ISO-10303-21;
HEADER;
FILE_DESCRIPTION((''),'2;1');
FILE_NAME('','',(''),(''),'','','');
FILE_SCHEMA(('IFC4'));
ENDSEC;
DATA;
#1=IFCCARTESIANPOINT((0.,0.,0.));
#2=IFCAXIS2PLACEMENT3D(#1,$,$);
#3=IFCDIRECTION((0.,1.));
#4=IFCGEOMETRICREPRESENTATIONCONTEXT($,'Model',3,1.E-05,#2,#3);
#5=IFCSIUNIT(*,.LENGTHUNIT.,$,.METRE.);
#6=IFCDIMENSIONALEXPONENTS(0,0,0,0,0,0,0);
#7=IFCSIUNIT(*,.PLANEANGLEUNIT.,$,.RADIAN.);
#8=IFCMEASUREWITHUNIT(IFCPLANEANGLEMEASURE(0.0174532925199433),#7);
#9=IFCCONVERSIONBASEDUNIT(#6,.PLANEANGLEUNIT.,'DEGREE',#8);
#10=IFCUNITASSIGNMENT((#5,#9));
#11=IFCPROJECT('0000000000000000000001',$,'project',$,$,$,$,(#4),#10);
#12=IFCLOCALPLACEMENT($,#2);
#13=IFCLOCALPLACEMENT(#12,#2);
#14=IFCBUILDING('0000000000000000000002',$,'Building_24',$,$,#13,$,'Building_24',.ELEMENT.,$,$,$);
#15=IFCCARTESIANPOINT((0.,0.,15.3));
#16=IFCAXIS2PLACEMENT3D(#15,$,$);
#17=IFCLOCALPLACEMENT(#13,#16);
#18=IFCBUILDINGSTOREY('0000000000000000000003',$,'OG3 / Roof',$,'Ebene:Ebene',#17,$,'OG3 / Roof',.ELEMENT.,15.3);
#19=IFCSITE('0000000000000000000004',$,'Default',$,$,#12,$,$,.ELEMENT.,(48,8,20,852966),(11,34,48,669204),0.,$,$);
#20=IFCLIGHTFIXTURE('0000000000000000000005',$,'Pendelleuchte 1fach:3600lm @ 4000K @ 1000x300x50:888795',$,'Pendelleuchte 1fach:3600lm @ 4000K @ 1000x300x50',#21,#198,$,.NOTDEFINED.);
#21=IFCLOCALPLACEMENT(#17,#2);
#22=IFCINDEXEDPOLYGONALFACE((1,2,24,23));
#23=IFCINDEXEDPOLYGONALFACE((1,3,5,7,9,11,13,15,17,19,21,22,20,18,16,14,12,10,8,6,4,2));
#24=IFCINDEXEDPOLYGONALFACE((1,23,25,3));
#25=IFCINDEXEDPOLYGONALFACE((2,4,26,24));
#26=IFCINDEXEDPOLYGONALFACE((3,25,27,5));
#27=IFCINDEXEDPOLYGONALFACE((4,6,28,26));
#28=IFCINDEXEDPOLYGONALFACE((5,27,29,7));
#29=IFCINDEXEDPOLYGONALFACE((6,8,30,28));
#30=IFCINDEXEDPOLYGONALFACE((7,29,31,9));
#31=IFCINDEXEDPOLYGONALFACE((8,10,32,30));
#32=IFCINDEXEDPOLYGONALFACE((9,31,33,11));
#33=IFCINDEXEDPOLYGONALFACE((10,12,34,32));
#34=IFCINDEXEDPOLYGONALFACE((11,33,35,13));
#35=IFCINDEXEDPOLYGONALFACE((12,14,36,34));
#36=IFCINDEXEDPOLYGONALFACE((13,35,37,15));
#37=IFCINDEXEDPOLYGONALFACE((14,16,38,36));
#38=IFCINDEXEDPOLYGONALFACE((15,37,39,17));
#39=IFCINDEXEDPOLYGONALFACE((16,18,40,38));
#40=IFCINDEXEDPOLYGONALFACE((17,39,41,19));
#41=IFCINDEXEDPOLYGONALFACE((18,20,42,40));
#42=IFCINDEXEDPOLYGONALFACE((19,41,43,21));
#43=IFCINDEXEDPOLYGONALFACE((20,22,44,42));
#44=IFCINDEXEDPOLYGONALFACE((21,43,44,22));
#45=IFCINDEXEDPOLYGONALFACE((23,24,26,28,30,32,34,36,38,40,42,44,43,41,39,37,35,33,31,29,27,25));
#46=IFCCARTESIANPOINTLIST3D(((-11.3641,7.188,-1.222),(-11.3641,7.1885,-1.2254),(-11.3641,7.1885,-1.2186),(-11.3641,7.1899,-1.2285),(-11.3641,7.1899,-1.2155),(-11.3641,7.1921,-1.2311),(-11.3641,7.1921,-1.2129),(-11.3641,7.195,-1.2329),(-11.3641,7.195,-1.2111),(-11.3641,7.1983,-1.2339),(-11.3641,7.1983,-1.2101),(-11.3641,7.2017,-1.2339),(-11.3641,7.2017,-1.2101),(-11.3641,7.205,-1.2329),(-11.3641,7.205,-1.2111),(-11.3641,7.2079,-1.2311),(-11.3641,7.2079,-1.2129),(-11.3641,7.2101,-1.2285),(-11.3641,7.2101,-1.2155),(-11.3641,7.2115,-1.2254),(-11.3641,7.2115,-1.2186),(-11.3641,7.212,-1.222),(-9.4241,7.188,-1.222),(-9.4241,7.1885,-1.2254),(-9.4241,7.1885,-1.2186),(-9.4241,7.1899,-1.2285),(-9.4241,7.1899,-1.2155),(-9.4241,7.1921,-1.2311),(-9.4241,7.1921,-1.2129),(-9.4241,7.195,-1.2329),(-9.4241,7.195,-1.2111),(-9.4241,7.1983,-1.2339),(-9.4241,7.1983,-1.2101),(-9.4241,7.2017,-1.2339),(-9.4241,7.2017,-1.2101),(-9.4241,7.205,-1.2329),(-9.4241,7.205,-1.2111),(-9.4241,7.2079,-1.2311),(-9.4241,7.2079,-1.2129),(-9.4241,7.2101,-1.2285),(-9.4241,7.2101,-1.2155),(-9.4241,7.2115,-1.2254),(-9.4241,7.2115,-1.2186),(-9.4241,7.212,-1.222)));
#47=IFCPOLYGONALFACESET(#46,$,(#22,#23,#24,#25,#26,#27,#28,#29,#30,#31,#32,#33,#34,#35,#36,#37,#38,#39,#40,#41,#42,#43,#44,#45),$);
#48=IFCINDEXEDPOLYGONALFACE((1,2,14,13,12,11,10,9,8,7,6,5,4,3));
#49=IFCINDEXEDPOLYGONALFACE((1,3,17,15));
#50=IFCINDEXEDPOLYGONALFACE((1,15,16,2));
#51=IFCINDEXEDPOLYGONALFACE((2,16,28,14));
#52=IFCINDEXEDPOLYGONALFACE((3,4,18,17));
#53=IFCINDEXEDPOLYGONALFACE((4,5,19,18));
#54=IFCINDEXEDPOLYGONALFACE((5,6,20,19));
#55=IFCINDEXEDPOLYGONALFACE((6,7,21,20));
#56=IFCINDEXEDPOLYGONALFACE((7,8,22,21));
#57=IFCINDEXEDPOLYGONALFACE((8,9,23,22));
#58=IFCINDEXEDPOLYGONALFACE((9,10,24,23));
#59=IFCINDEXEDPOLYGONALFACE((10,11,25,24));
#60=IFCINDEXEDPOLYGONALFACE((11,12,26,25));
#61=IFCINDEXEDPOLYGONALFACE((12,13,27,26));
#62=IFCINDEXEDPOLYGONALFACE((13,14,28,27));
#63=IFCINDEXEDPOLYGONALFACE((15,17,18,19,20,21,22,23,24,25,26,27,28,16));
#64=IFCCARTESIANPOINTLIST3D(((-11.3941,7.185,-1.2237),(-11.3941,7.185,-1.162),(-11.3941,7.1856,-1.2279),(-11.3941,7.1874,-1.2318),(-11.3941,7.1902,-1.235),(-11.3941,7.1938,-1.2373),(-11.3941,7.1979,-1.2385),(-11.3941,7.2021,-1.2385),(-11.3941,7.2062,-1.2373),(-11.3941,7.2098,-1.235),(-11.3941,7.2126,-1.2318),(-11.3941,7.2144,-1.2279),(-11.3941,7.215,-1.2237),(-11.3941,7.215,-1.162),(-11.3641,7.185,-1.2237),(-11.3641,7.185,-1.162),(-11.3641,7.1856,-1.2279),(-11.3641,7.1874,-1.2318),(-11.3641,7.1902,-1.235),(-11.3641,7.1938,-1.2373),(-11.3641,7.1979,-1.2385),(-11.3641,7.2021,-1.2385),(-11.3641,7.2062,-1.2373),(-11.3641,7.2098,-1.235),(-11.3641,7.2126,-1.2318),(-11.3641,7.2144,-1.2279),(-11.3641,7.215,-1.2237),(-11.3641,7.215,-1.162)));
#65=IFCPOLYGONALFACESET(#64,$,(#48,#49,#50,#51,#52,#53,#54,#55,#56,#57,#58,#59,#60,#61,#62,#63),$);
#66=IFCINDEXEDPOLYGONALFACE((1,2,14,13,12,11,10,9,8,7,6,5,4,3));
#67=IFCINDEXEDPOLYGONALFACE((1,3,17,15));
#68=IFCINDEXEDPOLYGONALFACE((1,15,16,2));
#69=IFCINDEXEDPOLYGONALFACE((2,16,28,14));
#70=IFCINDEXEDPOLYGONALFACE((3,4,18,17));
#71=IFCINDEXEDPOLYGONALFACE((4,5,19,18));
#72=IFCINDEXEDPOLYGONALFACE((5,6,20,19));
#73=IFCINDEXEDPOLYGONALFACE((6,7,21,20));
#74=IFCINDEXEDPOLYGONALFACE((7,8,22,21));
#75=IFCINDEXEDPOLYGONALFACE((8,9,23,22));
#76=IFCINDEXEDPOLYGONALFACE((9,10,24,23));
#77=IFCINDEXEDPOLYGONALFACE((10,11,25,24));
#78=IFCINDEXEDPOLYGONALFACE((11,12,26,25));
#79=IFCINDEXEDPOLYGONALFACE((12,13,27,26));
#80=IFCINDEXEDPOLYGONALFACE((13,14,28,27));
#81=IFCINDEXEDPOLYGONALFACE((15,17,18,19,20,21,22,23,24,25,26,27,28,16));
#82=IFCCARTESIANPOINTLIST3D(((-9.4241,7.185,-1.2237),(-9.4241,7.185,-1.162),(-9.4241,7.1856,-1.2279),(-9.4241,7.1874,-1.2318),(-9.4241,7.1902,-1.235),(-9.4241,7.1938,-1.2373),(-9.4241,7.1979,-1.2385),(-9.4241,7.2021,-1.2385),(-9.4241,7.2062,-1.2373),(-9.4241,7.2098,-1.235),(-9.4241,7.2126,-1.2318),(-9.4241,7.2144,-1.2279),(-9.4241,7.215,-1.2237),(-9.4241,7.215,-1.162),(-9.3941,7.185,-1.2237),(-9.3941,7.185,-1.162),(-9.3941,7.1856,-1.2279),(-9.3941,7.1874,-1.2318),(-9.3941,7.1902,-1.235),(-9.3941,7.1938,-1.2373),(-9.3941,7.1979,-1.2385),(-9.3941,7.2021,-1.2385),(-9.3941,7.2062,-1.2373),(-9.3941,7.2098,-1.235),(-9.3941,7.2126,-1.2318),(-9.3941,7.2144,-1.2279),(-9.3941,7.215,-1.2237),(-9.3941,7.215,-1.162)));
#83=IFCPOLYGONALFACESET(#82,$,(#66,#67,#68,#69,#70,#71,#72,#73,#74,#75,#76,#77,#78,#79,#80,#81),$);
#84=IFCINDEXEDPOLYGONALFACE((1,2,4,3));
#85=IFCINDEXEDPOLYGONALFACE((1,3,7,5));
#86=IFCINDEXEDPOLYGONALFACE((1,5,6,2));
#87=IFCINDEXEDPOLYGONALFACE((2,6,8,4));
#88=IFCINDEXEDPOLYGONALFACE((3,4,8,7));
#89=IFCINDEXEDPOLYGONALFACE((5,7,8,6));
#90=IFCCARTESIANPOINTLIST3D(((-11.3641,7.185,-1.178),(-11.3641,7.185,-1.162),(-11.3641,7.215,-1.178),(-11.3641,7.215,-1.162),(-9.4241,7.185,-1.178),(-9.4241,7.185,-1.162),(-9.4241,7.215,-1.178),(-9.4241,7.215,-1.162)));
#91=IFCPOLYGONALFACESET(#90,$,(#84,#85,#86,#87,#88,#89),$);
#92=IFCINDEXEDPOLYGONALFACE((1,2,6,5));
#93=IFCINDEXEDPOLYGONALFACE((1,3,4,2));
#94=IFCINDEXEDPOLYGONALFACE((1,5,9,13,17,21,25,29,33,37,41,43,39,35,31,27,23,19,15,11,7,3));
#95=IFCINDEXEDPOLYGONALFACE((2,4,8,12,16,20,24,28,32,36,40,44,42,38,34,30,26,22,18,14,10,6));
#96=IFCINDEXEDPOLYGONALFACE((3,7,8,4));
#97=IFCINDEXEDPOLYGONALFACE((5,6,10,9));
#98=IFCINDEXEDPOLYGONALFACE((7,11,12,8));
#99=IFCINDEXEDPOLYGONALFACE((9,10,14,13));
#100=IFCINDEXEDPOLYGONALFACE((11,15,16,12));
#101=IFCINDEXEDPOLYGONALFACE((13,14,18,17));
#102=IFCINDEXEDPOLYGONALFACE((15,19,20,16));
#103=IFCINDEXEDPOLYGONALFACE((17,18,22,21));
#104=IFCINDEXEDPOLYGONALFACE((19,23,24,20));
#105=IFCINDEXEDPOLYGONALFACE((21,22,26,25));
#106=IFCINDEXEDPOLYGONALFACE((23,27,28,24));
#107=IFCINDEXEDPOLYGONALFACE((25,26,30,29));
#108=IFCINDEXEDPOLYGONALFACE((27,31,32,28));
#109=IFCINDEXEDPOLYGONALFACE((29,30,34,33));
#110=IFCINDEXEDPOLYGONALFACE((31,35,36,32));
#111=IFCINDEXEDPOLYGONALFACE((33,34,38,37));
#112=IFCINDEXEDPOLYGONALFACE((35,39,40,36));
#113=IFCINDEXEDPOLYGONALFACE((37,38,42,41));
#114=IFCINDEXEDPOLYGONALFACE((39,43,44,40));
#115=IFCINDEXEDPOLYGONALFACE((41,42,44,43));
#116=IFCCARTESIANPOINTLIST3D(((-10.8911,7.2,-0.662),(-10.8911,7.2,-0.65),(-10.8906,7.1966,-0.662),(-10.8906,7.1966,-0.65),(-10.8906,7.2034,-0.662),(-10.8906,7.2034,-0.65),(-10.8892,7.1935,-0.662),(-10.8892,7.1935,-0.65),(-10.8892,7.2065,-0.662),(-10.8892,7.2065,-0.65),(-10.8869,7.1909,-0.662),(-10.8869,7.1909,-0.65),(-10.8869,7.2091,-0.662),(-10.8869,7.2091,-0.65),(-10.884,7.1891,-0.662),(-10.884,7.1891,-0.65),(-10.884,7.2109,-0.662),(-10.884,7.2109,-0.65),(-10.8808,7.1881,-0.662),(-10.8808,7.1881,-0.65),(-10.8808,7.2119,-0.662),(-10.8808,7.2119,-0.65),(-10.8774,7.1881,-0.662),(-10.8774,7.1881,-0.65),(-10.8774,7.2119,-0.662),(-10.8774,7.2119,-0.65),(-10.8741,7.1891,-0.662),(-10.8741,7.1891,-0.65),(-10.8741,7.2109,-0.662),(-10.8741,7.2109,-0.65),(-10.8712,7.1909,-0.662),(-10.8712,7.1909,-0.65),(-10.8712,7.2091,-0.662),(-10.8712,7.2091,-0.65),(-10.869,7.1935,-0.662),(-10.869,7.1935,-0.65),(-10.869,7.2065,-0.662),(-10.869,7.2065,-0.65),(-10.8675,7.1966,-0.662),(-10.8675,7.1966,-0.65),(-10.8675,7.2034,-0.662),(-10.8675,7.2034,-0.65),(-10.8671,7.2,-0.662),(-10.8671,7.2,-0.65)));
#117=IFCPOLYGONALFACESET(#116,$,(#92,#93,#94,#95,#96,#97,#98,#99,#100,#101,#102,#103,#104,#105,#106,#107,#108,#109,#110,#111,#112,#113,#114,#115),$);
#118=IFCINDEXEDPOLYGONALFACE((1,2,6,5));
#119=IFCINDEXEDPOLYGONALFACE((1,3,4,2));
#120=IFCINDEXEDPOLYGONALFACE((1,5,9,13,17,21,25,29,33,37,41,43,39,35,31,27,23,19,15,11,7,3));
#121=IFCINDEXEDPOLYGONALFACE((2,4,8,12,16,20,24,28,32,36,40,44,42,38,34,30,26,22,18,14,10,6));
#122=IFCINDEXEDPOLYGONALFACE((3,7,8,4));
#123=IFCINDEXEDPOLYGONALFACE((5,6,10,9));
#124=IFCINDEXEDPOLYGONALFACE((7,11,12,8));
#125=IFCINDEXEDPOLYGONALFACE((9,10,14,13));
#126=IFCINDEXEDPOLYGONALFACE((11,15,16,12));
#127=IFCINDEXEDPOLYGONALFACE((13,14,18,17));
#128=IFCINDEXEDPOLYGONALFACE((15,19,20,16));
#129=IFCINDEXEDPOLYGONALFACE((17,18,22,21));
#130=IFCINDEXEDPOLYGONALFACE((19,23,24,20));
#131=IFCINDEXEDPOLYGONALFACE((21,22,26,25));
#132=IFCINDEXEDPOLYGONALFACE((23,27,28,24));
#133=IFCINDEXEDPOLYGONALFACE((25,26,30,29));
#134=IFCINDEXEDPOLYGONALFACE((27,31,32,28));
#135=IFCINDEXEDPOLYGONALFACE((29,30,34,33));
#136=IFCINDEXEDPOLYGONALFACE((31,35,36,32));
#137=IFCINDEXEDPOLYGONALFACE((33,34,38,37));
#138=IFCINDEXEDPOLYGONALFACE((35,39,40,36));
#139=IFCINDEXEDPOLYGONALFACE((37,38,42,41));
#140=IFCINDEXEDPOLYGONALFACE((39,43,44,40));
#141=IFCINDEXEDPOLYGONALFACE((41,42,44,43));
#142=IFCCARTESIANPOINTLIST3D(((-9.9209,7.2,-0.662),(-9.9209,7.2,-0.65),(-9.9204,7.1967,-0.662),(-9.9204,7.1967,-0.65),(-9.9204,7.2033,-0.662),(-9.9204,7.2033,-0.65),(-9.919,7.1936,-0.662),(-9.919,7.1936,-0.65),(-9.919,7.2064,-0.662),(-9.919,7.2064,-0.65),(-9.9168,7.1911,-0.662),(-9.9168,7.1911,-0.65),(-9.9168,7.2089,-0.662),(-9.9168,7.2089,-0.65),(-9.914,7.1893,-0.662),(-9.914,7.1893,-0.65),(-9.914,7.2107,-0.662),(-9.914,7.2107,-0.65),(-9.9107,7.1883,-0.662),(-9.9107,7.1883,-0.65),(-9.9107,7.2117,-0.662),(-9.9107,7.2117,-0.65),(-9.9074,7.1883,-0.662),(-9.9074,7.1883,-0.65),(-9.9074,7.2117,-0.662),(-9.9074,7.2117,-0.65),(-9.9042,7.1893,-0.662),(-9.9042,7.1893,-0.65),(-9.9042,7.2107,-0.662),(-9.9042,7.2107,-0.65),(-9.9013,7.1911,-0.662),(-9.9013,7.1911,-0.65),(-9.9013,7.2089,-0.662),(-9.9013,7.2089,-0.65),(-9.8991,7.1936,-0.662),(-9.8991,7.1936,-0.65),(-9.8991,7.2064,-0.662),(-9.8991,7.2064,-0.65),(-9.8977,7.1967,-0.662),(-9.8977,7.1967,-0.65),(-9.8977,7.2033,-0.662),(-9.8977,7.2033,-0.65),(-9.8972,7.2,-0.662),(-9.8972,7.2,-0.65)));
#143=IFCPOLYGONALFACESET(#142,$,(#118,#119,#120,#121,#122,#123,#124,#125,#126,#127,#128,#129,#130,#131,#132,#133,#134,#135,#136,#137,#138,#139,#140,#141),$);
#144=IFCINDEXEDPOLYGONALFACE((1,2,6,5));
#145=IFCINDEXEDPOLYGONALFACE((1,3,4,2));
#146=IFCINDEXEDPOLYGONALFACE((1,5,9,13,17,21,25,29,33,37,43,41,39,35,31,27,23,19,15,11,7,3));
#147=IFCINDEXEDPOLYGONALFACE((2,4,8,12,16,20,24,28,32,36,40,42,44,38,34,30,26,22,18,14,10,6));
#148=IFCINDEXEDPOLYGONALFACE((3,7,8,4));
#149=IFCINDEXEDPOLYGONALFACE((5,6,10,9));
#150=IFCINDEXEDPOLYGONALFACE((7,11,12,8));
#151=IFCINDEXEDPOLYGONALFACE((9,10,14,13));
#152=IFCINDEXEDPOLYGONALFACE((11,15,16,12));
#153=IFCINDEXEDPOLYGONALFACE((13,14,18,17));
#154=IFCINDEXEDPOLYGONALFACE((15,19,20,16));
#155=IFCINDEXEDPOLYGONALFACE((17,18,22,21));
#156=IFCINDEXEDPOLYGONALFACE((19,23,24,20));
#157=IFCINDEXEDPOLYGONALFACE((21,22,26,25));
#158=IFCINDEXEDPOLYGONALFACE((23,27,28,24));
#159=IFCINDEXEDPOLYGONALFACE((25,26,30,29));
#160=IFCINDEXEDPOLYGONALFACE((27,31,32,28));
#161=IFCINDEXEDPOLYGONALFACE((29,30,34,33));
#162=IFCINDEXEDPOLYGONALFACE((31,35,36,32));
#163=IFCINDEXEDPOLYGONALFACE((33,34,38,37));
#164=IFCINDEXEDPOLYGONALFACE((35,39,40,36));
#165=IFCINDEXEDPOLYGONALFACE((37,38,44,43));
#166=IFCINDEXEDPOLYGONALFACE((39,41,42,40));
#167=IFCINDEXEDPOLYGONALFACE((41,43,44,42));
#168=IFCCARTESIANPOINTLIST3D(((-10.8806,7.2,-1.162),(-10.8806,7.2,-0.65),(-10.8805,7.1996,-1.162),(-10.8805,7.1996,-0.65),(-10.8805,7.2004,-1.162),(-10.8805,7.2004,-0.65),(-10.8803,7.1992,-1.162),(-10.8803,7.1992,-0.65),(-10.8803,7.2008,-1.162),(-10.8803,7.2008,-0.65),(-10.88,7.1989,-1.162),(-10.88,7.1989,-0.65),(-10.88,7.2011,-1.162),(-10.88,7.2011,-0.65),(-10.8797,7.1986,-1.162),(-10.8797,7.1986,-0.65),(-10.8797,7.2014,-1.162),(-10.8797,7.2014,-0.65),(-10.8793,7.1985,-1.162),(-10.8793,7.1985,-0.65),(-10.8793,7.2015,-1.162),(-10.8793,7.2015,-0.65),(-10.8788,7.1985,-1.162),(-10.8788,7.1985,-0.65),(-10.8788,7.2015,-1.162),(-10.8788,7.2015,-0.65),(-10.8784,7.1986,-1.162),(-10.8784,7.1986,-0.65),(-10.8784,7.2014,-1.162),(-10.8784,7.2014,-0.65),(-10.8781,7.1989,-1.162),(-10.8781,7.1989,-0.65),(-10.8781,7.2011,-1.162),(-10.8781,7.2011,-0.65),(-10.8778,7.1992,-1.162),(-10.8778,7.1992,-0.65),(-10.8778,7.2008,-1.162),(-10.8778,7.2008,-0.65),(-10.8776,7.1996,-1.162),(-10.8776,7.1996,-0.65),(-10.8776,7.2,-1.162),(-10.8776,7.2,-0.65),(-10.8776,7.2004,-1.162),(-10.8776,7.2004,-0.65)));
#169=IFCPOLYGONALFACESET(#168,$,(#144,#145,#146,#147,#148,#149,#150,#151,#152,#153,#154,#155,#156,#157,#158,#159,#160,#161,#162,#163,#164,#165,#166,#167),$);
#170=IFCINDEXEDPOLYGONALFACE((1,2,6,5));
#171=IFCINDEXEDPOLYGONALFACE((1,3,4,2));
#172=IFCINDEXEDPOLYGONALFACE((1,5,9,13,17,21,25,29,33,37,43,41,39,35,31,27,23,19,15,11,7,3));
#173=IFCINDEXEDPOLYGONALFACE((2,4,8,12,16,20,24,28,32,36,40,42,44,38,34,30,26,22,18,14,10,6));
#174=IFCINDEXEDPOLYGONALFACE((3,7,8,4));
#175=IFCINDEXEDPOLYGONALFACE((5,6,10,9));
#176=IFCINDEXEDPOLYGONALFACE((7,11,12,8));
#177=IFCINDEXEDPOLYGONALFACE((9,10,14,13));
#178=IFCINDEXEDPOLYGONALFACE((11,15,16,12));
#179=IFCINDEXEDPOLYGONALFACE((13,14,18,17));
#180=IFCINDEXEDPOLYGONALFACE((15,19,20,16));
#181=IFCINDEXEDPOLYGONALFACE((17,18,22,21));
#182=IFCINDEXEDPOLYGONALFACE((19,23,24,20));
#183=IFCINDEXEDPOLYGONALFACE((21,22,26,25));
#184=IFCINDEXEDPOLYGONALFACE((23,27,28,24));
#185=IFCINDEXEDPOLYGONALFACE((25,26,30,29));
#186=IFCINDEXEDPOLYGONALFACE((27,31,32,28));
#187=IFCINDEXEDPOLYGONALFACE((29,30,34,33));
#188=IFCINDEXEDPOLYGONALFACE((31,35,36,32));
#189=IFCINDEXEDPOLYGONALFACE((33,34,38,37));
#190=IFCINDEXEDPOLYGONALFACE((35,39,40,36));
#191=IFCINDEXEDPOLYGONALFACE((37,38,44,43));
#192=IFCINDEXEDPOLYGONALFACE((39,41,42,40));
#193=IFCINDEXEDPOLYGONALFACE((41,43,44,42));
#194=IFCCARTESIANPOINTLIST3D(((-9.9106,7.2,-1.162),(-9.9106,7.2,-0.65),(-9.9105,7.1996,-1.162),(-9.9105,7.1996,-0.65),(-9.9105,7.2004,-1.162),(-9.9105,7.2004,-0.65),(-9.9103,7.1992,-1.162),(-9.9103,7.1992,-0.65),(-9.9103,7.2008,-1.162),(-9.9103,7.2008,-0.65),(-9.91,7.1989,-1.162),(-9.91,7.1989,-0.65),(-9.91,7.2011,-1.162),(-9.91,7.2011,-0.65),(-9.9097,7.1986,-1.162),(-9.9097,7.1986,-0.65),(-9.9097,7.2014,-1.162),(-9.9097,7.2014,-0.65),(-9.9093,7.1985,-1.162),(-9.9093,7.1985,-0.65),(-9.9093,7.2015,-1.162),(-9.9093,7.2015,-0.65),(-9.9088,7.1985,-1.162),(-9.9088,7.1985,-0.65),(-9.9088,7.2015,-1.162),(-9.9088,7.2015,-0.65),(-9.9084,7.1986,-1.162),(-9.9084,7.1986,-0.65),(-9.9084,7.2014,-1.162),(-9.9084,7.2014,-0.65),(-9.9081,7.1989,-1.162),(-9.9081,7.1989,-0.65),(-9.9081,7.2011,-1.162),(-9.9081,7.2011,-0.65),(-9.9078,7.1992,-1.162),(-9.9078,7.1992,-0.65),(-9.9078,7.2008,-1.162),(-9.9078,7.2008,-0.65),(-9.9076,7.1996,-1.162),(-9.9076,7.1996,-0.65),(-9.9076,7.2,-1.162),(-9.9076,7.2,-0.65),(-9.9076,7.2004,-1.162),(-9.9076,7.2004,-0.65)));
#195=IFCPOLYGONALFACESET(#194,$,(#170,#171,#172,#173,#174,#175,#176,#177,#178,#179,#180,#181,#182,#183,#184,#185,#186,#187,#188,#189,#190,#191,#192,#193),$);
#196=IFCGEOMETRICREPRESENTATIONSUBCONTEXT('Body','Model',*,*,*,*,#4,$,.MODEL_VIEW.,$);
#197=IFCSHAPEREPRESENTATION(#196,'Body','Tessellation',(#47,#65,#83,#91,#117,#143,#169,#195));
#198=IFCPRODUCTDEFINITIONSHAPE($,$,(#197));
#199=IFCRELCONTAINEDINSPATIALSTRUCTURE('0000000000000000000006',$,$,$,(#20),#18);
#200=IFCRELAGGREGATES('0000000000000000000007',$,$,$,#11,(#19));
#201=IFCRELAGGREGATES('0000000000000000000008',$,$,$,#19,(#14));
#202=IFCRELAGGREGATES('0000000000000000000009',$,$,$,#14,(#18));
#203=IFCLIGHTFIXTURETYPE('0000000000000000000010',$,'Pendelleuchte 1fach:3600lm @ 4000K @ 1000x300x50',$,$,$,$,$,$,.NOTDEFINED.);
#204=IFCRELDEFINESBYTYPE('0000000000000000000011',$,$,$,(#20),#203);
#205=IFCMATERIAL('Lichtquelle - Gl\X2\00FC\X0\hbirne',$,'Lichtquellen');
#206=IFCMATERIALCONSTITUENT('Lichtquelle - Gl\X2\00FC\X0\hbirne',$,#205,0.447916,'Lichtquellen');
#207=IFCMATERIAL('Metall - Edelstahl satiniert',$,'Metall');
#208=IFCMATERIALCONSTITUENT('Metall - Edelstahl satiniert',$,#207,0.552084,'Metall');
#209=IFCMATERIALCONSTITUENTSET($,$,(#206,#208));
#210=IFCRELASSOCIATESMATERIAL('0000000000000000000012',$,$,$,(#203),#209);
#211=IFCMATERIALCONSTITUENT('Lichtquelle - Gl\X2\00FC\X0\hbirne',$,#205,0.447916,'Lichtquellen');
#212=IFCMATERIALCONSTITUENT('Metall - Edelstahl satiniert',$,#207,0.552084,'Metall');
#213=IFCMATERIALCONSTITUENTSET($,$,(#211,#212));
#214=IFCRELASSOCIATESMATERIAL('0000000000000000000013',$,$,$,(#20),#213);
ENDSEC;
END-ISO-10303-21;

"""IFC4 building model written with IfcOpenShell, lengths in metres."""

from ifc_helpers import new_model, entity, si_unit, converted_unit, direction, frame, origin, place, context, subcontext, project, spatial, line, arc, indexed_curve, outline, extrude, source, transform, mapped, material, constituent, constituent_set, type_object, type_shapes, element, save


model = new_model("IFC4")

# Units and contexts
model_context = context("Model", 3, precision=1e-05, world=origin(), true_north=direction((0.0, 1.0)))
body_context = subcontext(model_context, "Body", "Model", "MODEL_VIEW")
ifc_project = project(units=[si_unit("LENGTHUNIT", "METRE"), converted_unit("PLANEANGLEUNIT", "DEGREE", entity("IfcPlaneAngleMeasure", 0.0174532925199433), si_unit("PLANEANGLEUNIT", "RADIAN"), dimensions=[0, 0, 0, 0, 0, 0, 0])], contexts=[model_context])

# Site, building, storey
site_placement = place(None, origin())
site = spatial("IfcSite", under=ifc_project, at=site_placement, Name="Default", CompositionType="ELEMENT", RefLatitude=(48, 8, 20, 852966), RefLongitude=(11, 34, 48, 669204), RefElevation=0.0)
building_placement = place(site_placement, origin())
building = spatial("IfcBuilding", under=site, at=building_placement, Name="Building_24", LongName="Building_24", CompositionType="ELEMENT")
storey_placement = place(building_placement, frame((0.0, 0.0, 15.3)))
storey = spatial("IfcBuildingStorey", under=building, at=storey_placement, Name="OG3 / Roof", ObjectType="Ebene:Ebene", LongName="OG3 / Roof", CompositionType="ELEMENT", Elevation=15.3)

# Light fixture
ifc_material_1 = material(Name="Lichtquelle - Glühbirne", Category="Lichtquellen")
ifc_material_2 = material(Name="Metall - Edelstahl satiniert", Category="Metall")
ifc_constituent_1 = constituent(ifc_material_1, Name="Lichtquelle - Glühbirne", Category="Lichtquellen", fraction=0.447916)
ifc_constituent_2 = constituent(ifc_material_2, Name="Metall - Edelstahl satiniert", Category="Metall", fraction=0.552084)
ifc_constituent_set_1 = constituent_set(constituents=[ifc_constituent_1, ifc_constituent_2])
light_fixture_type_1 = type_object("IfcLightFixtureType", Name="Pendelleuchte 1fach:3600lm @ 4000K @ 1000x300x50", PredefinedType="NOTDEFINED", material=ifc_constituent_set_1)
shared_shape_1 = source(origin(), body_context, "Body", "SweptSolid", [
    extrude(outline(indexed_curve([(-0.012, 0.0), (0.0, -0.012), (0.012, 0.0), (0.0, 0.012)], segments=[arc(1, 2, 3), arc(3, 4, 1)], self_intersect=False)), frame((-0.97, 0.0, -0.572), z_axis=(1.0, 0.0, 0.0), x_axis=(0.0, 1.0, 0.0)), (0.0, 0.0, 1.0), 1.94),
    extrude(outline(indexed_curve([(-0.0308, -0.015), (0.0308, -0.015), (0.0308, 0.015), (-0.0308, 0.015), (-0.0458, 0.0)], segments=[line(1, 2, 3, 4), arc(4, 5, 1)], self_intersect=False)), frame((0.97, 0.0, -0.5428), z_axis=(1.0, 0.0, 0.0), x_axis=(0.0, 0.0, 1.0)), (0.0, 0.0, 1.0), 0.03),
    extrude(outline(indexed_curve([(-0.0308, -0.015), (0.0308, -0.015), (0.0308, 0.015), (-0.0308, 0.015), (-0.0458, 0.0)], segments=[line(1, 2, 3, 4), arc(4, 5, 1)], self_intersect=False)), frame((-1.0, 0.0, -0.5428), z_axis=(1.0, 0.0, 0.0), x_axis=(0.0, 0.0, 1.0)), (0.0, 0.0, 1.0), 0.03),
    extrude(outline(indexed_curve([(-0.97, -0.015), (0.97, -0.015), (0.97, 0.015), (-0.97, 0.015), (-0.97, -0.015)], self_intersect=False)), frame((0.0, 0.0, -0.528), z_axis=(0.0, 0.0, 1.0), x_axis=(-1.0, 0.0, 0.0)), (0.0, 0.0, 1.0), 0.016),
    extrude(outline(indexed_curve([(-0.012, 0.0), (0.0, -0.012), (0.012, 0.0), (0.0, 0.012)], segments=[arc(1, 2, 3), arc(3, 4, 1)], self_intersect=False)), frame((0.485, 0.0, -0.012)), (0.0, 0.0, 1.0), 0.012),
    extrude(outline(indexed_curve([(-0.0118, 0.0), (0.0, -0.0118), (0.0118, 0.0), (0.0, 0.0118)], segments=[arc(1, 2, 3), arc(3, 4, 1)], self_intersect=False)), frame((-0.485, 0.0, -0.012)), (0.0, 0.0, 1.0), 0.012),
    extrude(outline(indexed_curve([(-0.0015, 0.0), (0.0, -0.0015), (0.0015, 0.0), (0.0, 0.0015)], segments=[arc(1, 2, 3), arc(3, 4, 1)], self_intersect=False)), frame((0.485, 0.0, -0.512)), (0.0, 0.0, 1.0), 0.512),
    extrude(outline(indexed_curve([(-0.0015, 0.0), (0.0, -0.0015), (0.0015, 0.0), (0.0, 0.0015)], segments=[arc(1, 2, 3), arc(3, 4, 1)], self_intersect=False)), frame((-0.485, 0.0, -0.512)), (0.0, 0.0, 1.0), 0.512),
])
type_shapes(light_fixture_type_1, [shared_shape_1])
ifc_constituent_3 = constituent(ifc_material_1, Name="Lichtquelle - Glühbirne", Category="Lichtquellen", fraction=0.447916)
ifc_constituent_4 = constituent(ifc_material_2, Name="Metall - Edelstahl satiniert", Category="Metall", fraction=0.552084)
ifc_constituent_set_2 = constituent_set(constituents=[ifc_constituent_3, ifc_constituent_4])
light_fixture_1_placement = place(storey_placement, frame((-10.3941, 7.2, -0.65), z_axis=(0.0, 0.0, 1.0), x_axis=(-1.0, 0.0, 0.0)))
element("IfcLightFixture", 1, at=light_fixture_1_placement, inside=storey, type_object=light_fixture_type_1, material=ifc_constituent_set_2, Name="Pendelleuchte 1fach:3600lm @ 4000K @ 1000x300x50:888795", ObjectType="Pendelleuchte 1fach:3600lm @ 4000K @ 1000x300x50", PredefinedType="NOTDEFINED", context=body_context, shape_type="MappedRepresentation", body=[
    mapped(shared_shape_1, transform((0.0, 0.0, 0.0), scale=1.0)),
])

save(model, "model.ifc")
